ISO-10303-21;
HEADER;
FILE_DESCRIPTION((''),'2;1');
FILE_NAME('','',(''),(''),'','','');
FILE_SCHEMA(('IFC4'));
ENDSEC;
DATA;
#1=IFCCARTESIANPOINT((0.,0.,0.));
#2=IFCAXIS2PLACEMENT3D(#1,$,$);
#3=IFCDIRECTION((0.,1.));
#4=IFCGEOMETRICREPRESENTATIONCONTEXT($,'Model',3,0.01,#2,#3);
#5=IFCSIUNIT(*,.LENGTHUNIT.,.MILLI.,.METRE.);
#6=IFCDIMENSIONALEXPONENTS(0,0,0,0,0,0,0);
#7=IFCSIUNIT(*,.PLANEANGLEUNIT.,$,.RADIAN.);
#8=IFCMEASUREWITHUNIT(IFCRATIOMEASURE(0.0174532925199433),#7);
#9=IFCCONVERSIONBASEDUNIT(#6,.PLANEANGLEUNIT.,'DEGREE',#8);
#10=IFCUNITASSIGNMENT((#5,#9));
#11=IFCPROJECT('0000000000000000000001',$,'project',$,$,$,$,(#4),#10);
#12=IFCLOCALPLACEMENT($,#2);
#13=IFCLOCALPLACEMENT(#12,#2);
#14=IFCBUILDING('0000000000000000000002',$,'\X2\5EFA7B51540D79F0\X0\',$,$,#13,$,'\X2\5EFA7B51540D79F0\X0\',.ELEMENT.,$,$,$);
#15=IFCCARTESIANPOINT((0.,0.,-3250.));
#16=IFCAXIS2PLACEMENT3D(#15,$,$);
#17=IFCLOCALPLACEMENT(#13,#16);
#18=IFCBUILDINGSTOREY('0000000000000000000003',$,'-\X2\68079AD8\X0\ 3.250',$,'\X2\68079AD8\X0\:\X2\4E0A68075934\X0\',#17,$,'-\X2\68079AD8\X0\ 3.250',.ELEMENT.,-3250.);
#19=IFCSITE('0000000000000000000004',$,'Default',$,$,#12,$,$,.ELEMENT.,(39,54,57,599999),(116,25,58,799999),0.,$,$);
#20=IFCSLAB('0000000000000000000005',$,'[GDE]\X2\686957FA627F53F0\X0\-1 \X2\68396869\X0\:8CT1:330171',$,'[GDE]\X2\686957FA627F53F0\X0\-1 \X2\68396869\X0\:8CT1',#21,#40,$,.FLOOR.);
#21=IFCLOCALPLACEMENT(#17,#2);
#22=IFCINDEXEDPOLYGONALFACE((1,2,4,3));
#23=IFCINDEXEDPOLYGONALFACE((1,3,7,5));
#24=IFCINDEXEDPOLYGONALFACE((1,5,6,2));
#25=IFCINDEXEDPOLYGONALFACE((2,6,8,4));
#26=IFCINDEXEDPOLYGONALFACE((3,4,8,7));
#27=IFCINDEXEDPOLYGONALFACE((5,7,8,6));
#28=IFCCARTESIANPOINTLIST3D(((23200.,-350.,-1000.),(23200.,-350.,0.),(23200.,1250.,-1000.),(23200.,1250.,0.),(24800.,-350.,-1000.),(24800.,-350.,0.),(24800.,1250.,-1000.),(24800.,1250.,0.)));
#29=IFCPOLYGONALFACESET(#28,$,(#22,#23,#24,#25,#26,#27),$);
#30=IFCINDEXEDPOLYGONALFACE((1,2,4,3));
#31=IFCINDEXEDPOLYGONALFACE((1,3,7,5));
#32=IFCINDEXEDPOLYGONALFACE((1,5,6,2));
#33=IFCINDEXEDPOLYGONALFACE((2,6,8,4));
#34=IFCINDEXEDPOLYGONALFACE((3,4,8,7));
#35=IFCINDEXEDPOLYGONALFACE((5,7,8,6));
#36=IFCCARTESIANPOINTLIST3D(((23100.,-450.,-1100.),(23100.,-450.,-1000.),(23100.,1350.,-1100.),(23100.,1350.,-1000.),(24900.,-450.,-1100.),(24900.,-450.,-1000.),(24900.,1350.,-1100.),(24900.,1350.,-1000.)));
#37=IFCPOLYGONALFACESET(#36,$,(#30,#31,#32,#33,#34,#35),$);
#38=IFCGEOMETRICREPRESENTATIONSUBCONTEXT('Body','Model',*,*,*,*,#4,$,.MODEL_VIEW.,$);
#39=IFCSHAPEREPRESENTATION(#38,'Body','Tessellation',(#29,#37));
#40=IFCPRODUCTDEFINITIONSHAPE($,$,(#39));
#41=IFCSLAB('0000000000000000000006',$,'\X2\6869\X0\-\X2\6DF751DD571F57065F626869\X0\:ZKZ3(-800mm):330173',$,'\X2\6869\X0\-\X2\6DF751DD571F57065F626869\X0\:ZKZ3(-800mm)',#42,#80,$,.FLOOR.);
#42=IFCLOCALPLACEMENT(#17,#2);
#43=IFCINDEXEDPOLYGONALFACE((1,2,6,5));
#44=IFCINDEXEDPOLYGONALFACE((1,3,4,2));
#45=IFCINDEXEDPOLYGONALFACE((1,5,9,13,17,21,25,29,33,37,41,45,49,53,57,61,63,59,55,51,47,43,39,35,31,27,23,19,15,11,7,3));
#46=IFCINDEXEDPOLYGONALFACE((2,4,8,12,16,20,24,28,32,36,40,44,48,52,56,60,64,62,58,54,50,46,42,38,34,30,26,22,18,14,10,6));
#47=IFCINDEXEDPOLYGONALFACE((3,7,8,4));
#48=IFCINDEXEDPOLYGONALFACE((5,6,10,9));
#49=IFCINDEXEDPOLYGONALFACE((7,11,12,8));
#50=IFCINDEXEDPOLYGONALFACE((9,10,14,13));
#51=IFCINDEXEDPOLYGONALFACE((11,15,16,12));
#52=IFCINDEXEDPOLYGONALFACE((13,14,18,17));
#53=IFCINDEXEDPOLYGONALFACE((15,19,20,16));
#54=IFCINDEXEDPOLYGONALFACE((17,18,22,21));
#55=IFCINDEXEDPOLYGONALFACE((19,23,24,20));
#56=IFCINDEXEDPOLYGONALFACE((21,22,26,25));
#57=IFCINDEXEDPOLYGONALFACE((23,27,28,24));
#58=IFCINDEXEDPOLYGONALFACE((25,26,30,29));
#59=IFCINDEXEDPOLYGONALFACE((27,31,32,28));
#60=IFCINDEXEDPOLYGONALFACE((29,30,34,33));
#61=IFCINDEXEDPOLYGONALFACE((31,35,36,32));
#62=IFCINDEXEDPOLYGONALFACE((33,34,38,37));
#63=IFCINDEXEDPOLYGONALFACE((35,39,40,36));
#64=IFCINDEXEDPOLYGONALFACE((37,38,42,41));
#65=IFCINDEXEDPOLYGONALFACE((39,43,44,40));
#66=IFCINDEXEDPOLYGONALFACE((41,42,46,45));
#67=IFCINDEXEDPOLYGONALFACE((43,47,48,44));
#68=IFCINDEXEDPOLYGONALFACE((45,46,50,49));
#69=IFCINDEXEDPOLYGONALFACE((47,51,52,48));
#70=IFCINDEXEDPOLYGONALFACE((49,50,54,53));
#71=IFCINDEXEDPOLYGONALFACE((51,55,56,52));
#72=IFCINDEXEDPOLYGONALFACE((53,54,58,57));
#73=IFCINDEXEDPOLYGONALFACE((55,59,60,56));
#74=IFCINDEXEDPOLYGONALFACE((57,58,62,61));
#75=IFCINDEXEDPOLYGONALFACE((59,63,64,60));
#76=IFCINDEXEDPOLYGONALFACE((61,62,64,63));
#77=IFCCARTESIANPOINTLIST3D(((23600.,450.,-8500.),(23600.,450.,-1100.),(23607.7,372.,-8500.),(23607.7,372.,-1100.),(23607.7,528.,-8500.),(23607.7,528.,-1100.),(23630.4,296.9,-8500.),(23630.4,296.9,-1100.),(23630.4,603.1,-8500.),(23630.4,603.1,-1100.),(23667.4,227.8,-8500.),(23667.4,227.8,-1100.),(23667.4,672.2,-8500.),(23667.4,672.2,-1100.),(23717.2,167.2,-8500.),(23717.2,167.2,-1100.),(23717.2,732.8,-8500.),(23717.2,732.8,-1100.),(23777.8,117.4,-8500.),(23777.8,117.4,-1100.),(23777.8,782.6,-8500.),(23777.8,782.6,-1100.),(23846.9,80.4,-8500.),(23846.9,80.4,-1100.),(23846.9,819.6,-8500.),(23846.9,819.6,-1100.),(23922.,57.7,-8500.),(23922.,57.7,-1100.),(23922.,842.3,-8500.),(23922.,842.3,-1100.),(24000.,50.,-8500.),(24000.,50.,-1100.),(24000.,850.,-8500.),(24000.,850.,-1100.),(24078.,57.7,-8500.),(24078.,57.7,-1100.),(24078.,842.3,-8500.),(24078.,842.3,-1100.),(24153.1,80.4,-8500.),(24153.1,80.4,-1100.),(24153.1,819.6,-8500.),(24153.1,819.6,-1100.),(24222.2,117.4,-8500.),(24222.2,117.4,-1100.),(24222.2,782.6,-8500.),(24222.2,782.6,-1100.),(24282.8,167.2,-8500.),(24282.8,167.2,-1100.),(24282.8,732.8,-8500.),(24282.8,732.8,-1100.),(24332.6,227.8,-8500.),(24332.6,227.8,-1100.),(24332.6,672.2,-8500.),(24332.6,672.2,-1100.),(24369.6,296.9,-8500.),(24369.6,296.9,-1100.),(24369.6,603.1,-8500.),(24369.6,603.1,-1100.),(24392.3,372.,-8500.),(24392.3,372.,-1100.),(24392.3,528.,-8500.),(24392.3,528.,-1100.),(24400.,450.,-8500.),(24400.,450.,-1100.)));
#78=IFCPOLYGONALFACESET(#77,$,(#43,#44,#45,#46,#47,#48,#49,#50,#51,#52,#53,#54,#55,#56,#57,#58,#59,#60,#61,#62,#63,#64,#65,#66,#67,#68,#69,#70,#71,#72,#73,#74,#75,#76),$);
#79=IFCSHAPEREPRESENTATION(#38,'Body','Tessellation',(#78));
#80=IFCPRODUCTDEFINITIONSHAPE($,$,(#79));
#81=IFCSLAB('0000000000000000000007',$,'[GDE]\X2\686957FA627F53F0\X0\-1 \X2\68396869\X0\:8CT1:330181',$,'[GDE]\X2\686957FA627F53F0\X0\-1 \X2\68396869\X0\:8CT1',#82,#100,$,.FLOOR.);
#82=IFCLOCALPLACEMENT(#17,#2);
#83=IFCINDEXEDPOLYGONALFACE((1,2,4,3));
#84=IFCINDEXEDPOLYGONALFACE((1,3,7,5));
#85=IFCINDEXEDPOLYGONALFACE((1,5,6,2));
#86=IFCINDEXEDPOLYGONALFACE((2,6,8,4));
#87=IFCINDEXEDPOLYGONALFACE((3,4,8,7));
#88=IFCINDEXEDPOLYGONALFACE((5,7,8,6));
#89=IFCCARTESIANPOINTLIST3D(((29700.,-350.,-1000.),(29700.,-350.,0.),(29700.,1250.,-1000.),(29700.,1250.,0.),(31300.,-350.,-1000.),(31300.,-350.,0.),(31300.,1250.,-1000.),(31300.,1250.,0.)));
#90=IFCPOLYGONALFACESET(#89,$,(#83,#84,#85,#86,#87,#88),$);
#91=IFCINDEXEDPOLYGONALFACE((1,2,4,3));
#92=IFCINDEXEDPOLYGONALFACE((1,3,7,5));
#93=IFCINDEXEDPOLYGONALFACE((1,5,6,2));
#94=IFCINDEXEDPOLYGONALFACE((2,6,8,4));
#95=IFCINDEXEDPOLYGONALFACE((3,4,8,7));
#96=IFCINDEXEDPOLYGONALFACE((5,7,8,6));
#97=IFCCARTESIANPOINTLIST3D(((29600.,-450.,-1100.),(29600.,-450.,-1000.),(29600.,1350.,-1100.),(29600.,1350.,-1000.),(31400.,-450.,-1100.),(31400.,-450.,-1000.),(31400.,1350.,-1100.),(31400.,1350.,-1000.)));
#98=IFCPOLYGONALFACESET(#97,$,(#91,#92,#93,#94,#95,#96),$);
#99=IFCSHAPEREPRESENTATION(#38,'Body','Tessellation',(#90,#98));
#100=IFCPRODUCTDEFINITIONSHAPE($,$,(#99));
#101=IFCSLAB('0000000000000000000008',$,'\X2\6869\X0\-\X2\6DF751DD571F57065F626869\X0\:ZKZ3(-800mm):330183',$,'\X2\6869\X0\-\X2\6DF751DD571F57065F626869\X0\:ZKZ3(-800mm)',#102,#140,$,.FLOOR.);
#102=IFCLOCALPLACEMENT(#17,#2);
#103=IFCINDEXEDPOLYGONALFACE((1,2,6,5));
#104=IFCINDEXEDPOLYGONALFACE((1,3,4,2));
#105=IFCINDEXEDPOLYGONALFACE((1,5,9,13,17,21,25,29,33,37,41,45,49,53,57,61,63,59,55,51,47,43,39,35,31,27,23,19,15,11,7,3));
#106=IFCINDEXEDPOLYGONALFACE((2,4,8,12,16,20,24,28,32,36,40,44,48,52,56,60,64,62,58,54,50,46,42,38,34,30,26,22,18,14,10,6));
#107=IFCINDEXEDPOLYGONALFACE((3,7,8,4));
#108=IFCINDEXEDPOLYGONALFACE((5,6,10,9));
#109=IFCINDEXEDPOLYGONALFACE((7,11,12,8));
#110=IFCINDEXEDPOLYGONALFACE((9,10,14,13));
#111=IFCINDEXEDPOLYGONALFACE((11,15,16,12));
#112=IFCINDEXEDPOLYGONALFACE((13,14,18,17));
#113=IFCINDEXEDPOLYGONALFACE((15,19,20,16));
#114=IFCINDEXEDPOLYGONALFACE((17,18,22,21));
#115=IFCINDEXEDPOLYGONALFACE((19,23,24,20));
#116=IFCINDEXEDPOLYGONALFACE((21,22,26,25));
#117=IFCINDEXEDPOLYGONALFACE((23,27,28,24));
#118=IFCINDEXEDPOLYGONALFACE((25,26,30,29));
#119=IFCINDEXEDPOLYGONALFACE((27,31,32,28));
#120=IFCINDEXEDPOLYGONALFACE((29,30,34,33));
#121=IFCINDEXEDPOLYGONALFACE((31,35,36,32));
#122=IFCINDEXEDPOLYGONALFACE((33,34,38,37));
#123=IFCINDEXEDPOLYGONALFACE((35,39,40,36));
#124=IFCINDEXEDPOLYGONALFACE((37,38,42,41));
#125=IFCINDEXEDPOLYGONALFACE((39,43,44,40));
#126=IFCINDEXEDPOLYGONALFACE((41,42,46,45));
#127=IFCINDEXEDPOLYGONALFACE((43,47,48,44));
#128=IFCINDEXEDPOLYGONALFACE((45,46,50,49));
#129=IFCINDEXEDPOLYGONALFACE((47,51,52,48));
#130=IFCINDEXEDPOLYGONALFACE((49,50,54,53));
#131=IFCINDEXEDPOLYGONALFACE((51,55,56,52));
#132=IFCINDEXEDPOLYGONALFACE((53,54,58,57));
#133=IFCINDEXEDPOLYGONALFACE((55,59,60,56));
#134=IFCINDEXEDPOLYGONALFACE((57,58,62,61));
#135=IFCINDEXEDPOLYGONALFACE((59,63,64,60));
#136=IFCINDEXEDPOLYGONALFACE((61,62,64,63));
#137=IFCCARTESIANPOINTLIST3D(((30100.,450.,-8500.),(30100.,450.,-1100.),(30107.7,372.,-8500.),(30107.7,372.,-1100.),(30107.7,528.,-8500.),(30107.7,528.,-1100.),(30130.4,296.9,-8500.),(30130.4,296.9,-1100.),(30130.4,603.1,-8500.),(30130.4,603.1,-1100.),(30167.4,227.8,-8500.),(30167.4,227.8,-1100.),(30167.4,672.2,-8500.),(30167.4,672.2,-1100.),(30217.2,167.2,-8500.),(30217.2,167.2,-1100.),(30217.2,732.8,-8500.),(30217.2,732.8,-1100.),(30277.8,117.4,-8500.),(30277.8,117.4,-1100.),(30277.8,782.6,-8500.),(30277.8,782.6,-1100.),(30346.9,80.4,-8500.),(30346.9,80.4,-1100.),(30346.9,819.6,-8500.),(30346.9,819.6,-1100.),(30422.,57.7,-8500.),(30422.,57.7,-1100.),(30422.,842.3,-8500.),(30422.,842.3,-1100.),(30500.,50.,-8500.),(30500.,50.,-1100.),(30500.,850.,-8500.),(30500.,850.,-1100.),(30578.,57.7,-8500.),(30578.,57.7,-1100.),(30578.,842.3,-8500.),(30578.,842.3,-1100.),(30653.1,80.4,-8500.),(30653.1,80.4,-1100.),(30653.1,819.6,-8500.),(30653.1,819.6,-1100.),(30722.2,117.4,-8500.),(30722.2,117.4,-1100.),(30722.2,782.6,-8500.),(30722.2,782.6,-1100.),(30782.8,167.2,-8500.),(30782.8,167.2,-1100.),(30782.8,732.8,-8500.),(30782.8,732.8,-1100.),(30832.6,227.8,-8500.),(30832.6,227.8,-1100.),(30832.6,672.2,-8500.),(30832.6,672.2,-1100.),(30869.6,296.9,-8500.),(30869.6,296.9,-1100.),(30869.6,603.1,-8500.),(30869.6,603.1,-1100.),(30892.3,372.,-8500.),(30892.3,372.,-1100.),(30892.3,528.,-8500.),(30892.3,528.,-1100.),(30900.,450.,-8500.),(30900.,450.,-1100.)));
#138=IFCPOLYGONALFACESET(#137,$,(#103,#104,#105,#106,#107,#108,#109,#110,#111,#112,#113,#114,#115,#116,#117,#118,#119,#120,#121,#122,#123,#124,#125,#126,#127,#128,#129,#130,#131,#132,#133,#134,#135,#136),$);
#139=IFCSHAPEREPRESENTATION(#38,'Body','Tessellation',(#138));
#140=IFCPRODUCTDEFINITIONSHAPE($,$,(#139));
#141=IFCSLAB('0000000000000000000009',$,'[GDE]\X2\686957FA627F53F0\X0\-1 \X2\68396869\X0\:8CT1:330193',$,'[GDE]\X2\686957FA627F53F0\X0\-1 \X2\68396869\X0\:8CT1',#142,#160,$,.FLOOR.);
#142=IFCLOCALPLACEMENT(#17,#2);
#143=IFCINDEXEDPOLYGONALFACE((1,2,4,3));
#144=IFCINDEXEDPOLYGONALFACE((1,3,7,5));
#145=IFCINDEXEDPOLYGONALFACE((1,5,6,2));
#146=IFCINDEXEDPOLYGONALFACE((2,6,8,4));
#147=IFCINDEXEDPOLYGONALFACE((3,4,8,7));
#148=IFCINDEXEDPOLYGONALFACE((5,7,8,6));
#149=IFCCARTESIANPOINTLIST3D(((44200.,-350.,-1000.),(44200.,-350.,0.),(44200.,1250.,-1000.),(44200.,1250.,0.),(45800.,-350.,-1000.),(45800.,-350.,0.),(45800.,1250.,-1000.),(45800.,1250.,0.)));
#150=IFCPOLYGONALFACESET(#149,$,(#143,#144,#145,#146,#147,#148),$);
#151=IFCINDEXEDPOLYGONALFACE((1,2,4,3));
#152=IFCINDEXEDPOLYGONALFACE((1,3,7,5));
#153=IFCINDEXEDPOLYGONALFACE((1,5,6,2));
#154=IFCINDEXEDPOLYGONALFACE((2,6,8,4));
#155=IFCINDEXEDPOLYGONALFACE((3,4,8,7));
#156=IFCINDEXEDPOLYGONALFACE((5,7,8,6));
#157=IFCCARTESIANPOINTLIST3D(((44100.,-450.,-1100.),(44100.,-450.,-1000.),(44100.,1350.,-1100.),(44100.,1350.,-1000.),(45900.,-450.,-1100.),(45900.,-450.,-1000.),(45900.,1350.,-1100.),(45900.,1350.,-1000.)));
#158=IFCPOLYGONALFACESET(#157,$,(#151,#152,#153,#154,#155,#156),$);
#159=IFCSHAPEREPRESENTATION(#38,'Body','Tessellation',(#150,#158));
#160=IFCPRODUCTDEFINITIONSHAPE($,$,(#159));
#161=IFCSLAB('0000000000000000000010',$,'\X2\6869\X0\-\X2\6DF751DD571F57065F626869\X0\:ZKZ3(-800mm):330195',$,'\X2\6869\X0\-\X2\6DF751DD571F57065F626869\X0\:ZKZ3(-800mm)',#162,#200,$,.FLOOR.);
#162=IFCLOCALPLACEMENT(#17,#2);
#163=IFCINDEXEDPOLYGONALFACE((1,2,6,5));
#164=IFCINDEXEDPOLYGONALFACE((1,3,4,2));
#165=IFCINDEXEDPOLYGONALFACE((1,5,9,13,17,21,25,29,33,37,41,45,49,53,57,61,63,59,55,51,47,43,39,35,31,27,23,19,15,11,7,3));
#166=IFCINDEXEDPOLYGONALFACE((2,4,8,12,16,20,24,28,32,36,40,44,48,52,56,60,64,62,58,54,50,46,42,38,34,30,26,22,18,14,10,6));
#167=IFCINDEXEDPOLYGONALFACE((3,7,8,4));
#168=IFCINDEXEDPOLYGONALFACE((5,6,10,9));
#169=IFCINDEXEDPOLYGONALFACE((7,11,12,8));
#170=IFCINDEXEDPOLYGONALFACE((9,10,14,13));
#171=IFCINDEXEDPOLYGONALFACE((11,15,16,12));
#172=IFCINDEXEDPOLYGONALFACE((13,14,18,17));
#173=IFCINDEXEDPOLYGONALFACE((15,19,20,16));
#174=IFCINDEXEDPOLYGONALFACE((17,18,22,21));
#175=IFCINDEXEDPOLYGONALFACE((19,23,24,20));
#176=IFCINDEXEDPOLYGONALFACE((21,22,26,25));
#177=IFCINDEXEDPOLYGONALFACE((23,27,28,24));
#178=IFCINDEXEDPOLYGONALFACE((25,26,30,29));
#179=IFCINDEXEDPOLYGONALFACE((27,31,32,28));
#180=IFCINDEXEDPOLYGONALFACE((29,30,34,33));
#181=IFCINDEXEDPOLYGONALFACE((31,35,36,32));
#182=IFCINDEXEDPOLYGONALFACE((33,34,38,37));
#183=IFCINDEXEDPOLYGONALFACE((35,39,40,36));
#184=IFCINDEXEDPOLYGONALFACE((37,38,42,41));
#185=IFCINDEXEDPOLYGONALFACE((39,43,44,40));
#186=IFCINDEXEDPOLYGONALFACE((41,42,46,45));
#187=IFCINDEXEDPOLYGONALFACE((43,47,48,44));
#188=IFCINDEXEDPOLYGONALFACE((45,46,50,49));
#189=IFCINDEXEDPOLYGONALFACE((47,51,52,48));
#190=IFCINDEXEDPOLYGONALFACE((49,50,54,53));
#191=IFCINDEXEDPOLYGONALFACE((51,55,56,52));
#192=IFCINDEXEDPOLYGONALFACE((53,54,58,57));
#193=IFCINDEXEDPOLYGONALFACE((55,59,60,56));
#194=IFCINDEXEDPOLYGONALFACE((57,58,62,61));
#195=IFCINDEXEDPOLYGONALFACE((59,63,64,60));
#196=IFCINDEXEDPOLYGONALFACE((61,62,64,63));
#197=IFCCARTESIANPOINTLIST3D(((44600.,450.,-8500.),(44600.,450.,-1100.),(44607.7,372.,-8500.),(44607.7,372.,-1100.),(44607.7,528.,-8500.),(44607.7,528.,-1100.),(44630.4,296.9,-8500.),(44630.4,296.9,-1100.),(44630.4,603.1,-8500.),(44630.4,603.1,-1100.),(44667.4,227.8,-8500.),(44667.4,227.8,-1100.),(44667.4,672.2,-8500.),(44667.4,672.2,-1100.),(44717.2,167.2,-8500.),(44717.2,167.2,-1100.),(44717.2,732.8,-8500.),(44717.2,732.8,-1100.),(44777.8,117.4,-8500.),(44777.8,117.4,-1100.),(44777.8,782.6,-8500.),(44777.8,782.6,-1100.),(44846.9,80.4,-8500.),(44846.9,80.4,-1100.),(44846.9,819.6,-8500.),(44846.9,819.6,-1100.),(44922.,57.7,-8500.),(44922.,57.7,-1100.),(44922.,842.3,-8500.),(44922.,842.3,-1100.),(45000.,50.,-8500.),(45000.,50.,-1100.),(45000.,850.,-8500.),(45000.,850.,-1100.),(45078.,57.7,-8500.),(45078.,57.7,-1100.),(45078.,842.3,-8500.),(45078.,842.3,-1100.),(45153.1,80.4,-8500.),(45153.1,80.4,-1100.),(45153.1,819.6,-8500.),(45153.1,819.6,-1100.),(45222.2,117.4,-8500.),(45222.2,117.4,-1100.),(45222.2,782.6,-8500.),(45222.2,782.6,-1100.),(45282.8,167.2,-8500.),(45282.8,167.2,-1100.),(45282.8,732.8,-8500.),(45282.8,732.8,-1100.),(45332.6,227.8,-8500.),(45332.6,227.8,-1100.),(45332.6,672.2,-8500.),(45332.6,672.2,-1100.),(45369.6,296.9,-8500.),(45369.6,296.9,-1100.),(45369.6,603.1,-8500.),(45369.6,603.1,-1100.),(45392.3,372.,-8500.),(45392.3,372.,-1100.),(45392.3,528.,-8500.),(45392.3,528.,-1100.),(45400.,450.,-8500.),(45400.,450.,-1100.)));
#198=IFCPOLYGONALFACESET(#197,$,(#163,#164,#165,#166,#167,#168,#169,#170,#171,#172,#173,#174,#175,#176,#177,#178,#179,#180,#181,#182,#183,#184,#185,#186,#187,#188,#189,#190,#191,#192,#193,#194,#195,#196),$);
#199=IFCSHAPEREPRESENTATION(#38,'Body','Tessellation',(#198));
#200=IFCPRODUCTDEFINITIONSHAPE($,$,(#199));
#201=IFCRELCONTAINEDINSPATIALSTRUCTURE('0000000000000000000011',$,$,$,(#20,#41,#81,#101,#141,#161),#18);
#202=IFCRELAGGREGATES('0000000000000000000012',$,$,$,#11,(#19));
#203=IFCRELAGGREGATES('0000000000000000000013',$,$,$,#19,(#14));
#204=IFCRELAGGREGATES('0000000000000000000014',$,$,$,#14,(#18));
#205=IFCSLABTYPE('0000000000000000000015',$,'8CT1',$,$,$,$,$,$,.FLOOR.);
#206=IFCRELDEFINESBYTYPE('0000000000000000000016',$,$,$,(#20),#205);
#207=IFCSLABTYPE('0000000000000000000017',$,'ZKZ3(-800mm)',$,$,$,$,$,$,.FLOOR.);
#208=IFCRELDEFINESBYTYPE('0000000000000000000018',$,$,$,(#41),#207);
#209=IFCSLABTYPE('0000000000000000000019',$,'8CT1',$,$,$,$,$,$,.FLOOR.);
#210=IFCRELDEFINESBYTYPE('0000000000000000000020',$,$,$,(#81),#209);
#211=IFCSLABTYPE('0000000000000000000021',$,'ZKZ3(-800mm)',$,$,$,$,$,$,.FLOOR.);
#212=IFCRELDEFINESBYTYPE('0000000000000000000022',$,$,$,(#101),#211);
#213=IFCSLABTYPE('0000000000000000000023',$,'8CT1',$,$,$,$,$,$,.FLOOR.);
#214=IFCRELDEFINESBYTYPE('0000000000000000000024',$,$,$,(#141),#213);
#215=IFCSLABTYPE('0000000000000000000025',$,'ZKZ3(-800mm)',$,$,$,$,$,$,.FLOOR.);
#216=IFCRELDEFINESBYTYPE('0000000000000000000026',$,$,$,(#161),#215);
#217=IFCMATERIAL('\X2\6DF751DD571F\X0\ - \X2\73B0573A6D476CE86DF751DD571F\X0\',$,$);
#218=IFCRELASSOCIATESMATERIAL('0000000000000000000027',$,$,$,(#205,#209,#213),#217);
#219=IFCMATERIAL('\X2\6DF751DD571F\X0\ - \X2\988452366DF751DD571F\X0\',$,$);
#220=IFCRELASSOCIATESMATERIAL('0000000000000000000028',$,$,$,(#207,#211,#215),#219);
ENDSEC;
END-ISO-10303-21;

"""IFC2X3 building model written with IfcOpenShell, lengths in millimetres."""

from ifc_helpers import new_model, entity, si_unit, converted_unit, direction, frame, frame_2d, origin, origin_2d_with_axis, place, context, subcontext, project, spatial, rectangle, circle, extrude, material, type_object, element, save


model = new_model("IFC2X3")

# Units and contexts
model_context = context("Model", 3, precision=0.01, world=origin(), true_north=direction((0.0, 1.0)))
body_context = subcontext(model_context, "Body", "Model", "MODEL_VIEW")
ifc_project = project(units=[si_unit("LENGTHUNIT", "METRE", prefix="MILLI"), converted_unit("PLANEANGLEUNIT", "DEGREE", entity("IfcRatioMeasure", 0.0174532925199433), si_unit("PLANEANGLEUNIT", "RADIAN"), dimensions=[0, 0, 0, 0, 0, 0, 0])], contexts=[model_context])

# Site, building, storey
site_placement = place(None, origin())
site = spatial("IfcSite", under=ifc_project, at=site_placement, Name="Default", CompositionType="ELEMENT", RefLatitude=(39, 54, 57, 599999), RefLongitude=(116, 25, 58, 799999), RefElevation=0.0)
building_placement = place(site_placement, origin())
building = spatial("IfcBuilding", under=site, at=building_placement, Name="建筑名称", LongName="建筑名称", CompositionType="ELEMENT")
storey_placement = place(building_placement, frame((0.0, 0.0, -3250.0)))
storey = spatial("IfcBuildingStorey", under=building, at=storey_placement, Name="-标高 3.250", ObjectType="标高:上标头", LongName="-标高 3.250", CompositionType="ELEMENT", Elevation=-3250.0)

# Slabs
ifc_material_1 = material(Name="混凝土 - 现场浇注混凝土")
slab_type_1 = type_object("IfcSlabType", Name="8CT1", PredefinedType="FLOOR", material=ifc_material_1)
slab_1_placement = place(storey_placement, origin())
element("IfcSlab", 1, at=slab_1_placement, inside=storey, type_object=slab_type_1, Name="[GDE]桩基承台-1 根桩:8CT1:330171", ObjectType="[GDE]桩基承台-1 根桩:8CT1", PredefinedType="FLOOR", context=body_context, shape_type="SweptSolid", body=[
    extrude(rectangle(XDim=1600.0, YDim=1600.0, at=origin_2d_with_axis()), frame((24000.0, 450.0, -1000.0), z_axis=(0.0, 0.0, 1.0), x_axis=(-1.0, 0.0, 0.0)), (0.0, 0.0, 1.0), 1000.0),
    extrude(rectangle(XDim=1800.0, YDim=1800.0, at=origin_2d_with_axis()), frame((24000.0, 450.0, -1100.0), z_axis=(0.0, 0.0, 1.0), x_axis=(-1.0, 0.0, 0.0)), (0.0, 0.0, 1.0), 100.0),
])
ifc_material_2 = material(Name="混凝土 - 预制混凝土")
slab_type_2 = type_object("IfcSlabType", Name="ZKZ3(-800mm)", PredefinedType="FLOOR", material=ifc_material_2)
slab_2_placement = place(storey_placement, origin())
element("IfcSlab", 2, at=slab_2_placement, inside=storey, type_object=slab_type_2, Name="桩-混凝土圆形桩:ZKZ3(-800mm):330173", ObjectType="桩-混凝土圆形桩:ZKZ3(-800mm)", PredefinedType="FLOOR", context=body_context, shape_type="SweptSolid", body=[
    extrude(circle(Radius=400.0, at=frame_2d((0.0, 0.0), x_axis=(1.0, 0.0))), frame((24000.0, 450.0, -8500.0)), (0.0, 0.0, 1.0), 7400.0),
])
slab_type_3 = type_object("IfcSlabType", Name="8CT1", PredefinedType="FLOOR", material=ifc_material_1)
slab_3_placement = place(storey_placement, origin())
element("IfcSlab", 3, at=slab_3_placement, inside=storey, type_object=slab_type_3, Name="[GDE]桩基承台-1 根桩:8CT1:330181", ObjectType="[GDE]桩基承台-1 根桩:8CT1", PredefinedType="FLOOR", context=body_context, shape_type="SweptSolid", body=[
    extrude(rectangle(XDim=1600.0, YDim=1600.0, at=origin_2d_with_axis()), frame((30500.0, 450.0, -1000.0), z_axis=(0.0, 0.0, 1.0), x_axis=(-1.0, 0.0, 0.0)), (0.0, 0.0, 1.0), 1000.0),
    extrude(rectangle(XDim=1800.0, YDim=1800.0, at=frame_2d((0.0, 0.0), x_axis=(1.0, 0.0))), frame((30500.0, 450.0, -1100.0), z_axis=(0.0, 0.0, 1.0), x_axis=(-1.0, 0.0, 0.0)), (0.0, 0.0, 1.0), 100.0),
])
slab_type_4 = type_object("IfcSlabType", Name="ZKZ3(-800mm)", PredefinedType="FLOOR", material=ifc_material_2)
slab_4_placement = place(storey_placement, origin())
element("IfcSlab", 4, at=slab_4_placement, inside=storey, type_object=slab_type_4, Name="桩-混凝土圆形桩:ZKZ3(-800mm):330183", ObjectType="桩-混凝土圆形桩:ZKZ3(-800mm)", PredefinedType="FLOOR", context=body_context, shape_type="SweptSolid", body=[
    extrude(circle(Radius=400.0, at=frame_2d((0.0, 0.0), x_axis=(1.0, 0.0))), frame((30500.0, 450.0, -8500.0)), (0.0, 0.0, 1.0), 7400.0),
])
slab_type_5 = type_object("IfcSlabType", Name="8CT1", PredefinedType="FLOOR", material=ifc_material_1)
slab_5_placement = place(storey_placement, origin())
element("IfcSlab", 5, at=slab_5_placement, inside=storey, type_object=slab_type_5, Name="[GDE]桩基承台-1 根桩:8CT1:330193", ObjectType="[GDE]桩基承台-1 根桩:8CT1", PredefinedType="FLOOR", context=body_context, shape_type="SweptSolid", body=[
    extrude(rectangle(XDim=1600.0, YDim=1600.0, at=origin_2d_with_axis()), frame((45000.0, 450.0, -1000.0), z_axis=(0.0, 0.0, 1.0), x_axis=(-1.0, 0.0, 0.0)), (0.0, 0.0, 1.0), 1000.0),
    extrude(rectangle(XDim=1800.0, YDim=1800.0, at=frame_2d((0.0, 0.0), x_axis=(1.0, 0.0))), frame((45000.0, 450.0, -1100.0), z_axis=(0.0, 0.0, 1.0), x_axis=(-1.0, 0.0, 0.0)), (0.0, 0.0, 1.0), 100.0),
])
slab_type_6 = type_object("IfcSlabType", Name="ZKZ3(-800mm)", PredefinedType="FLOOR", material=ifc_material_2)
slab_6_placement = place(storey_placement, origin())
element("IfcSlab", 6, at=slab_6_placement, inside=storey, type_object=slab_type_6, Name="桩-混凝土圆形桩:ZKZ3(-800mm):330195", ObjectType="桩-混凝土圆形桩:ZKZ3(-800mm)", PredefinedType="FLOOR", context=body_context, shape_type="SweptSolid", body=[
    extrude(circle(Radius=400.0, at=frame_2d((0.0, 0.0), x_axis=(1.0, 0.0))), frame((45000.0, 450.0, -8500.0)), (0.0, 0.0, 1.0), 7400.0),
])

save(model, "model.ifc")
